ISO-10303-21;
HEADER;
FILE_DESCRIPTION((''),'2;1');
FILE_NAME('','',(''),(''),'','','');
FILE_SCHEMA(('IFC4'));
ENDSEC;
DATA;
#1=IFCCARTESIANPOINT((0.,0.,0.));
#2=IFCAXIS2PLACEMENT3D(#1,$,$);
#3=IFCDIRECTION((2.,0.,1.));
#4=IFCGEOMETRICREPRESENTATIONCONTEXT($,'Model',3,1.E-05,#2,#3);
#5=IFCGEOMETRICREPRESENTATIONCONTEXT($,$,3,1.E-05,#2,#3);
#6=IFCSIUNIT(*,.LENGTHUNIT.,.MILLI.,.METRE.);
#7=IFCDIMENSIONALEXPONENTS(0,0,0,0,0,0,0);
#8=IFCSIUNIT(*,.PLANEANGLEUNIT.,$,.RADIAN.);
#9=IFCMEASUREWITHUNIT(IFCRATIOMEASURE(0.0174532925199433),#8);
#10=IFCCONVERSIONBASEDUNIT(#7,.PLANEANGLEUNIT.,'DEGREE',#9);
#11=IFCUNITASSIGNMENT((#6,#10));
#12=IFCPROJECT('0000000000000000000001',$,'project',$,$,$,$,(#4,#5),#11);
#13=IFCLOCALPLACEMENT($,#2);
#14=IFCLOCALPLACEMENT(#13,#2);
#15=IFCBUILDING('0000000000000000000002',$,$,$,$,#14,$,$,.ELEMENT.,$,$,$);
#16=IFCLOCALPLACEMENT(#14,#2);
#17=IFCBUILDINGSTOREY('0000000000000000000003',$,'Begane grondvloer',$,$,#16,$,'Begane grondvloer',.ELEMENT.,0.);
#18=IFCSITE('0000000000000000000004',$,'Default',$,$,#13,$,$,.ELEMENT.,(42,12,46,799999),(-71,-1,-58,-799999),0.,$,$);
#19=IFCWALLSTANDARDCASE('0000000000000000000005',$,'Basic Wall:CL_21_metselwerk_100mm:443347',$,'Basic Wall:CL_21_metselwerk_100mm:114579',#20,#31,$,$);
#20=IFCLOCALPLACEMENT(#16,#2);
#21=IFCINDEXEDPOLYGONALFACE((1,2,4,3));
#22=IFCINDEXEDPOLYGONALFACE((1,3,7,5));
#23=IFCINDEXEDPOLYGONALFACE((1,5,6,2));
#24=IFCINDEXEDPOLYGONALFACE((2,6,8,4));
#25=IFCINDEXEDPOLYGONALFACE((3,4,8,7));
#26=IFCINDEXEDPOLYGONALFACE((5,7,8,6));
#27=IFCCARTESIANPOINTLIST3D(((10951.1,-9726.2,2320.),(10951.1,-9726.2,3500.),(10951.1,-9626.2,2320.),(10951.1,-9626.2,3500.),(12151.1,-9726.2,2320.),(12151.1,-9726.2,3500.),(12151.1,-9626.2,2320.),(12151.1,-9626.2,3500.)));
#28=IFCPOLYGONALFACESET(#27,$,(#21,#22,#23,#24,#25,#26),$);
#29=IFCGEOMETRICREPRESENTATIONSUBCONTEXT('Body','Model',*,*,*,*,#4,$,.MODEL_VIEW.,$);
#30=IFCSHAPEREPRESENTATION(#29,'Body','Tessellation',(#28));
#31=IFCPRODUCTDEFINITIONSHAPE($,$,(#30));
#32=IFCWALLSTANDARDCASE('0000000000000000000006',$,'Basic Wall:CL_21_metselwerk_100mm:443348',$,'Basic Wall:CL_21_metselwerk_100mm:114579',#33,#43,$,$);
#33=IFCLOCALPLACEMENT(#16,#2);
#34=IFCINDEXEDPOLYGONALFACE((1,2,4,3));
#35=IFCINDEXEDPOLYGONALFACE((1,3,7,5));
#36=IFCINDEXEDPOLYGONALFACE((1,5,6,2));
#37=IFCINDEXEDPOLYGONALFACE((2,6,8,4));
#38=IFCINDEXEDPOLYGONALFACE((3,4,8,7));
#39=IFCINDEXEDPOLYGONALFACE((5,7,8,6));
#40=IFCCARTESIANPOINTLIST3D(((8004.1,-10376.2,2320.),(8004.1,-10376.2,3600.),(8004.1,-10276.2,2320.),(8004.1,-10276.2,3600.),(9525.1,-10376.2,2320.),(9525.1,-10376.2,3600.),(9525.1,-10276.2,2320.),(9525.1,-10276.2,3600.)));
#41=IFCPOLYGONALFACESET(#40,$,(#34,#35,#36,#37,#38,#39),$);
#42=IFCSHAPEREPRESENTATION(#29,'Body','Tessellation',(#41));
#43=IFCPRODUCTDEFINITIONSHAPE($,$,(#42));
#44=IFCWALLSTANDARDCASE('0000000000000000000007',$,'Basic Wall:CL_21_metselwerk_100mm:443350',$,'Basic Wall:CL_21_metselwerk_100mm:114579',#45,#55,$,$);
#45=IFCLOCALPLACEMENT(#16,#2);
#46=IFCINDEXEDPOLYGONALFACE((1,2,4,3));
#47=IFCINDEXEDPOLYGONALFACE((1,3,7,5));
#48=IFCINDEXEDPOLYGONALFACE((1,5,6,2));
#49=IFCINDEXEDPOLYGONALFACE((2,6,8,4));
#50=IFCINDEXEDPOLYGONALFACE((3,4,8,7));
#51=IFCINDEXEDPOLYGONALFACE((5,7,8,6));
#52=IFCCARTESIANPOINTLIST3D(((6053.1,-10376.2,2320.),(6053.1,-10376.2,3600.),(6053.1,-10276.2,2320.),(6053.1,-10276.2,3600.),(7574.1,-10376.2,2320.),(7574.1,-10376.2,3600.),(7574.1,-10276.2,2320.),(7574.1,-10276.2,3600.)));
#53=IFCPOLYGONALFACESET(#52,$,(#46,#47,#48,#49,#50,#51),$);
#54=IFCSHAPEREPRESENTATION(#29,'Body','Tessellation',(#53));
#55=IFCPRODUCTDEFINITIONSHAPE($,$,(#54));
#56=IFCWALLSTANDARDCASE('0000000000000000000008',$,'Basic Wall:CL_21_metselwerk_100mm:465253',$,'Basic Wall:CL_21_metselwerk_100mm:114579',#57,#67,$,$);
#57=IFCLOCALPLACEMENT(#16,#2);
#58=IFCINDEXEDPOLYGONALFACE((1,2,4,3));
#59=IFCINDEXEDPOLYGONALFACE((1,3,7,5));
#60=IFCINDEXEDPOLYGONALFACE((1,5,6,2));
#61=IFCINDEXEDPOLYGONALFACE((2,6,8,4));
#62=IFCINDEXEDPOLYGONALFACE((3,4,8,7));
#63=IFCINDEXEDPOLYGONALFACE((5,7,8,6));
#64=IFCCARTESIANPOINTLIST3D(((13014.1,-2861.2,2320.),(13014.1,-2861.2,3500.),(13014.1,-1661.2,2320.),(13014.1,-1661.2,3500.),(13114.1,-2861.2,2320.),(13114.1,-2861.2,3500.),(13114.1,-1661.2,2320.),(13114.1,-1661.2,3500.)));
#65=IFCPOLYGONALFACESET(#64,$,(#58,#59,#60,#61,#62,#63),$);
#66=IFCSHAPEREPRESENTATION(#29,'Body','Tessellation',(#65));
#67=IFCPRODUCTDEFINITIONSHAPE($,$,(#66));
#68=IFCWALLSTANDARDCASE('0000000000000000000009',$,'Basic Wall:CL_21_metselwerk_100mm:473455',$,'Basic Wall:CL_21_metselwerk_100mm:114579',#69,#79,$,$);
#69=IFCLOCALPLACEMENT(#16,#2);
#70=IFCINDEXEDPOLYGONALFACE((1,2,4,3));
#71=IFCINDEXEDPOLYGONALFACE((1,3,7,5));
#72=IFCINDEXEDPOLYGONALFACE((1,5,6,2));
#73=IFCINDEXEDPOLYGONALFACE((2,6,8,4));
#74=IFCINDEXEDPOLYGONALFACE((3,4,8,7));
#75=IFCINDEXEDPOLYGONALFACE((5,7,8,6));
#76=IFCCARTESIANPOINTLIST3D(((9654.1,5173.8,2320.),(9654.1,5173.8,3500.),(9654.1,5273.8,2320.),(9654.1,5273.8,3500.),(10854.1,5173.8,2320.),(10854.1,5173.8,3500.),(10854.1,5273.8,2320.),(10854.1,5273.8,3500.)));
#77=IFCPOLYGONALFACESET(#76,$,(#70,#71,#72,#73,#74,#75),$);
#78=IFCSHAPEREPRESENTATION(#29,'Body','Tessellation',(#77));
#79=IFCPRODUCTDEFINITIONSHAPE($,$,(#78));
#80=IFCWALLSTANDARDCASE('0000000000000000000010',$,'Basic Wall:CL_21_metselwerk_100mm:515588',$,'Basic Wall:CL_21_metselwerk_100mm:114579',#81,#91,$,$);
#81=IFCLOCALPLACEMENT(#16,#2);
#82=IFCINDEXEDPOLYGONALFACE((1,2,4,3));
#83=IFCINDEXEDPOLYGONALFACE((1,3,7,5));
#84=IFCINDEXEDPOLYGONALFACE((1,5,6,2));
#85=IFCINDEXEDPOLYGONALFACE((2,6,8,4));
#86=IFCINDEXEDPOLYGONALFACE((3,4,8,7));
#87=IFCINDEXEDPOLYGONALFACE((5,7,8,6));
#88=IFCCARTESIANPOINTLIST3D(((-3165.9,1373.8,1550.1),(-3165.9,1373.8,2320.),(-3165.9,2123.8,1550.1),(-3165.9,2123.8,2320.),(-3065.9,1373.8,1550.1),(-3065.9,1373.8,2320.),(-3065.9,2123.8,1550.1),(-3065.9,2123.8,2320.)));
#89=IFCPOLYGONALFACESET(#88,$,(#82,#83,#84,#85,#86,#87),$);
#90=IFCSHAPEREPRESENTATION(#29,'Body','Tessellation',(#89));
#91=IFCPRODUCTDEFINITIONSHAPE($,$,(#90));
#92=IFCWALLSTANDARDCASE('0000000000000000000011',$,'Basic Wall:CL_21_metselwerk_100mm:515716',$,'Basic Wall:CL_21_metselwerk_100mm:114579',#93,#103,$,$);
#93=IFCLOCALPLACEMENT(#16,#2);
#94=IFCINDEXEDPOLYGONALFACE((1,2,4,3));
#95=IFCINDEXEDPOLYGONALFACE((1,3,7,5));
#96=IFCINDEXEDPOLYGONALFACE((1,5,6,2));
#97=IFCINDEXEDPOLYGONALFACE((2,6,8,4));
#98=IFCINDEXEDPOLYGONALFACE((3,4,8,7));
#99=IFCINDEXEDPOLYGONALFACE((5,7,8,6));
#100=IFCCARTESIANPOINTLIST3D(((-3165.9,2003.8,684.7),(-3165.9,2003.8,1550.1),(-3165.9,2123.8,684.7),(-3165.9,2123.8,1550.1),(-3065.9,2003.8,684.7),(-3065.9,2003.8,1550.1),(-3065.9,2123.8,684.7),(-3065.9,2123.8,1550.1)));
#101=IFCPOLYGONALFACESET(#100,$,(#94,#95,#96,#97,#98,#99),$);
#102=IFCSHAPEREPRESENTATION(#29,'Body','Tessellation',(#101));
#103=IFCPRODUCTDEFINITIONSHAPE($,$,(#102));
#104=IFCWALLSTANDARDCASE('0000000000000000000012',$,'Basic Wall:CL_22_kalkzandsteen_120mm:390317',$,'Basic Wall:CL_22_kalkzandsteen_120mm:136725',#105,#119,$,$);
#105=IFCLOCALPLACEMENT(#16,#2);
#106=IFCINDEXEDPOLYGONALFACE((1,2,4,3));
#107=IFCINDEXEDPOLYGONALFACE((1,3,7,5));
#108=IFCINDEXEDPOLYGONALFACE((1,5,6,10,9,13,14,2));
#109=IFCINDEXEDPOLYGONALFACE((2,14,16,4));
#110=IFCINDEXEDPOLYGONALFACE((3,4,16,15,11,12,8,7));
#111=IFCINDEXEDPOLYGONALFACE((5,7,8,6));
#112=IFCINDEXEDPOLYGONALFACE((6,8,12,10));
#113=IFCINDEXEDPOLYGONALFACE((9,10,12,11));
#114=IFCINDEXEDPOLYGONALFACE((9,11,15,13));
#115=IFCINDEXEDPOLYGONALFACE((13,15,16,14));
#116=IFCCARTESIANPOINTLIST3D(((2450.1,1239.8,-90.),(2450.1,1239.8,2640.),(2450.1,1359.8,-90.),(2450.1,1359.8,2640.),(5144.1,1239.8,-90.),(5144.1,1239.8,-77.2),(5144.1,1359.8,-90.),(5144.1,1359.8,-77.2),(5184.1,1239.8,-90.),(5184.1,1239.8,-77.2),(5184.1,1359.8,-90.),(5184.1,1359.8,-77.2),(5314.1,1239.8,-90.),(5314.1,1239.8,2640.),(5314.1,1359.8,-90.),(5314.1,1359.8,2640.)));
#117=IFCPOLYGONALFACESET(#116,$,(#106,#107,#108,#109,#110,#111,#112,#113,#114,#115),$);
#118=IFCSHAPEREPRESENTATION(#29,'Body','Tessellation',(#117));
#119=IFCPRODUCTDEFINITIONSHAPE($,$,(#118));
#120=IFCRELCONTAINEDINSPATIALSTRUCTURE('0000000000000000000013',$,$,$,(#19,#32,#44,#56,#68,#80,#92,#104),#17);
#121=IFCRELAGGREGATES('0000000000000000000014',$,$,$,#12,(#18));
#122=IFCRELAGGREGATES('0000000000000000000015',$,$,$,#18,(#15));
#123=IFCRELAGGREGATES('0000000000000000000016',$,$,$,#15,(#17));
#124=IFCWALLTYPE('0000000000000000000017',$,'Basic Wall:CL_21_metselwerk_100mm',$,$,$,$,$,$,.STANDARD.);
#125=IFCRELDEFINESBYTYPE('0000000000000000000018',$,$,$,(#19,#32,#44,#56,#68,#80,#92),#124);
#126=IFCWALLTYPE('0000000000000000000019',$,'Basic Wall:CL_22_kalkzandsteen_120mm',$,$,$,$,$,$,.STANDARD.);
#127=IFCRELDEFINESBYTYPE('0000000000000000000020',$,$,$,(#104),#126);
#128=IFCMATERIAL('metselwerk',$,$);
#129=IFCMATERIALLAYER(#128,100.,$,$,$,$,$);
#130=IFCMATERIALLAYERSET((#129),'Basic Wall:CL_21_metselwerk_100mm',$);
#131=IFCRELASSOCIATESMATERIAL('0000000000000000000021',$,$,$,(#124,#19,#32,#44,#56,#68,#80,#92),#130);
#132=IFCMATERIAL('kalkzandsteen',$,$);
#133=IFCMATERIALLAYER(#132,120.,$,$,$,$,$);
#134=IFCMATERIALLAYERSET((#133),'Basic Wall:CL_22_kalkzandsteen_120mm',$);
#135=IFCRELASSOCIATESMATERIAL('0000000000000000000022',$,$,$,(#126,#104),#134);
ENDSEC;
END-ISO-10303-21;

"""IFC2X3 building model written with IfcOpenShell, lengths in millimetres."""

from ifc_helpers import new_model, entity, si_unit, converted_unit, direction, frame, frame_2d, origin, place, context, subcontext, project, spatial, polyline, rectangle, extrude, clip, bounded_halfspace, material, layer, layer_set, layer_usage, type_object, element, save


model = new_model("IFC2X3")

# Units and contexts
model_context = context("Model", 3, precision=1e-05, world=origin(), true_north=direction((2.0, 0.0, 1.0)))
context_of_model = context(None, 3, precision=1e-05, world=origin(), true_north=direction((2.0, 0.0, 1.0)))
body_context = subcontext(model_context, "Body", "Model", "MODEL_VIEW")
ifc_project = project(units=[si_unit("LENGTHUNIT", "METRE", prefix="MILLI"), converted_unit("PLANEANGLEUNIT", "DEGREE", entity("IfcRatioMeasure", 0.0174532925199433), si_unit("PLANEANGLEUNIT", "RADIAN"), dimensions=[0, 0, 0, 0, 0, 0, 0])], contexts=[model_context, context_of_model])

# Site, building, storey
site_placement = place(None, origin())
site = spatial("IfcSite", under=ifc_project, at=site_placement, Name="Default", CompositionType="ELEMENT", RefLatitude=(42, 12, 46, 799999), RefLongitude=(-71, -1, -58, -799999), RefElevation=0.0)
building_placement = place(site_placement, origin())
building = spatial("IfcBuilding", under=site, at=building_placement, CompositionType="ELEMENT")
storey_placement = place(building_placement, origin())
storey = spatial("IfcBuildingStorey", under=building, at=storey_placement, Name="Begane grondvloer", LongName="Begane grondvloer", CompositionType="ELEMENT", Elevation=0.0)

# Walls
ifc_material_1 = material(Name="kalkzandsteen")
ifc_material_2 = material(Name="metselwerk")
ifc_layer_1 = layer(ifc_material_2, 100.0)
ifc_layer_set_1 = layer_set([ifc_layer_1], Name="Basic Wall:CL_21_metselwerk_100mm")
wall_type_1 = type_object("IfcWallType", Name="Basic Wall:CL_21_metselwerk_100mm", PredefinedType="STANDARD", material=ifc_layer_set_1)
ifc_layer_usage_1 = layer_usage(ifc_layer_set_1, "AXIS2", "POSITIVE", -50.0)
wall_1_placement = place(storey_placement, frame((12151.1, -9676.2, 2320.0), z_axis=(0.0, 0.0, 1.0), x_axis=(-1.0, 0.0, 0.0)))
element("IfcWallStandardCase", 1, at=wall_1_placement, inside=storey, type_object=wall_type_1, material=ifc_layer_usage_1, Name="Basic Wall:CL_21_metselwerk_100mm:443347", ObjectType="Basic Wall:CL_21_metselwerk_100mm:114579", context=body_context, shape_type="SweptSolid", body=[
    extrude(rectangle(XDim=1200.0, YDim=100.0, at=frame_2d((600.0, 0.0), x_axis=(-1.0, 0.0))), origin(), (0.0, 0.0, 1.0), 1180.0),
])
ifc_layer_usage_2 = layer_usage(ifc_layer_set_1, "AXIS2", "POSITIVE", -50.0)
wall_2_placement = place(storey_placement, frame((9525.1, -10326.2, 2320.0), z_axis=(0.0, 0.0, 1.0), x_axis=(-1.0, 0.0, 0.0)))
element("IfcWallStandardCase", 2, at=wall_2_placement, inside=storey, type_object=wall_type_1, material=ifc_layer_usage_2, Name="Basic Wall:CL_21_metselwerk_100mm:443348", ObjectType="Basic Wall:CL_21_metselwerk_100mm:114579", context=body_context, shape_type="SweptSolid", body=[
    extrude(rectangle(XDim=1521.0, YDim=100.0, at=frame_2d((760.5, 0.0), x_axis=(-1.0, 0.0))), origin(), (0.0, 0.0, 1.0), 1280.0),
])
ifc_layer_usage_3 = layer_usage(ifc_layer_set_1, "AXIS2", "POSITIVE", -50.0)
wall_3_placement = place(storey_placement, frame((7574.1, -10326.2, 2320.0), z_axis=(0.0, 0.0, 1.0), x_axis=(-1.0, 0.0, 0.0)))
element("IfcWallStandardCase", 3, at=wall_3_placement, inside=storey, type_object=wall_type_1, material=ifc_layer_usage_3, Name="Basic Wall:CL_21_metselwerk_100mm:443350", ObjectType="Basic Wall:CL_21_metselwerk_100mm:114579", context=body_context, shape_type="SweptSolid", body=[
    extrude(rectangle(XDim=1521.0, YDim=100.0, at=frame_2d((760.5, 0.0), x_axis=(-1.0, 0.0))), origin(), (0.0, 0.0, 1.0), 1280.0),
])
ifc_layer_usage_4 = layer_usage(ifc_layer_set_1, "AXIS2", "NEGATIVE", 50.0)
wall_4_placement = place(storey_placement, frame((13064.1, -2861.2, 2320.0), z_axis=(0.0, 0.0, 1.0), x_axis=(0.0, 1.0, 0.0)))
element("IfcWallStandardCase", 4, at=wall_4_placement, inside=storey, type_object=wall_type_1, material=ifc_layer_usage_4, Name="Basic Wall:CL_21_metselwerk_100mm:465253", ObjectType="Basic Wall:CL_21_metselwerk_100mm:114579", context=body_context, shape_type="SweptSolid", body=[
    extrude(rectangle(XDim=1200.0, YDim=100.0, at=frame_2d((600.0, 0.0), x_axis=(-1.0, 0.0))), origin(), (0.0, 0.0, 1.0), 1180.0),
])
ifc_layer_usage_5 = layer_usage(ifc_layer_set_1, "AXIS2", "NEGATIVE", 50.0)
wall_5_placement = place(storey_placement, frame((10854.1, 5223.8, 2320.0), z_axis=(0.0, 0.0, 1.0), x_axis=(-1.0, 0.0, 0.0)))
element("IfcWallStandardCase", 5, at=wall_5_placement, inside=storey, type_object=wall_type_1, material=ifc_layer_usage_5, Name="Basic Wall:CL_21_metselwerk_100mm:473455", ObjectType="Basic Wall:CL_21_metselwerk_100mm:114579", context=body_context, shape_type="SweptSolid", body=[
    extrude(rectangle(XDim=1200.0, YDim=100.0, at=frame_2d((600.0, 0.0), x_axis=(-1.0, 0.0))), origin(), (0.0, 0.0, 1.0), 1180.0),
])
ifc_layer_usage_6 = layer_usage(ifc_layer_set_1, "AXIS2", "NEGATIVE", 50.0)
wall_6_placement = place(storey_placement, frame((-3115.9, 2123.8, 1550.1), z_axis=(0.0, 0.0, 1.0), x_axis=(0.0, -1.0, 0.0)))
element("IfcWallStandardCase", 6, at=wall_6_placement, inside=storey, type_object=wall_type_1, material=ifc_layer_usage_6, Name="Basic Wall:CL_21_metselwerk_100mm:515588", ObjectType="Basic Wall:CL_21_metselwerk_100mm:114579", context=body_context, shape_type="SweptSolid", body=[
    extrude(rectangle(XDim=750.0, YDim=100.0, at=frame_2d((375.0, 0.0), x_axis=(-1.0, 0.0))), origin(), (0.0, 0.0, 1.0), 769.9),
])
ifc_layer_usage_7 = layer_usage(ifc_layer_set_1, "AXIS2", "NEGATIVE", 50.0)
wall_7_placement = place(storey_placement, frame((-3115.9, 2123.8, 684.7), z_axis=(0.0, 0.0, 1.0), x_axis=(0.0, -1.0, 0.0)))
element("IfcWallStandardCase", 7, at=wall_7_placement, inside=storey, type_object=wall_type_1, material=ifc_layer_usage_7, Name="Basic Wall:CL_21_metselwerk_100mm:515716", ObjectType="Basic Wall:CL_21_metselwerk_100mm:114579", context=body_context, shape_type="SweptSolid", body=[
    extrude(rectangle(XDim=119.9, YDim=100.0, at=frame_2d((60.0, 0.0), x_axis=(-1.0, 0.0))), origin(), (0.0, 0.0, 1.0), 865.4),
])
ifc_layer_2 = layer(ifc_material_1, 120.0)
ifc_layer_set_2 = layer_set([ifc_layer_2], Name="Basic Wall:CL_22_kalkzandsteen_120mm")
ifc_layer_usage_8 = layer_usage(ifc_layer_set_2, "AXIS2", "NEGATIVE", 60.0)
wall_type_2 = type_object("IfcWallType", Name="Basic Wall:CL_22_kalkzandsteen_120mm", PredefinedType="STANDARD", material=ifc_layer_set_2)
wall_8_placement = place(storey_placement, frame((5314.1, 1299.8, -90.0), z_axis=(0.0, 0.0, 1.0), x_axis=(-1.0, 0.0, 0.0)))
element("IfcWallStandardCase", 8, at=wall_8_placement, inside=storey, type_object=wall_type_2, material=ifc_layer_usage_8, Name="Basic Wall:CL_22_kalkzandsteen_120mm:390317", ObjectType="Basic Wall:CL_22_kalkzandsteen_120mm:136725", context=body_context, shape_type="Clipping", body=[
    clip(clip(clip(extrude(rectangle(XDim=2864.0, YDim=120.0, at=frame_2d((1432.0, 0.0), x_axis=(-1.0, 0.0))), origin(), (0.0, 0.0, 1.0), 2730.0), bounded_halfspace(frame((130.0, -60.0, 0.0), z_axis=(0.0, 0.0, 1.0), x_axis=(0.0, -1.0, 0.0)), True, frame((130.0, -60.0, 0.0)), polyline([(0.0, 0.0), (0.0, 120.0), (-130.0, 120.0), (-130.0, 0.0), (0.0, 0.0)]))), bounded_halfspace(frame((2864.0, -60.0, 0.0), z_axis=(0.0, 0.0, 1.0), x_axis=(0.0, -1.0, 0.0)), True, frame((2864.0, -60.0, 0.0)), polyline([(0.0, 0.0), (0.0, 120.0), (-2694.0, 120.0), (-2694.0, 0.0), (0.0, 0.0)]))), bounded_halfspace(frame((170.0, -60.0, 12.8), z_axis=(0.0, 0.0, -1.0), x_axis=(0.0, 1.0, 0.0)), False, frame((170.0, -60.0, 12.8)), polyline([(0.0, 0.0), (0.0, 120.0), (-40.0, 120.0), (-40.0, 0.0), (0.0, 0.0)]))),
])

save(model, "model.ifc")
